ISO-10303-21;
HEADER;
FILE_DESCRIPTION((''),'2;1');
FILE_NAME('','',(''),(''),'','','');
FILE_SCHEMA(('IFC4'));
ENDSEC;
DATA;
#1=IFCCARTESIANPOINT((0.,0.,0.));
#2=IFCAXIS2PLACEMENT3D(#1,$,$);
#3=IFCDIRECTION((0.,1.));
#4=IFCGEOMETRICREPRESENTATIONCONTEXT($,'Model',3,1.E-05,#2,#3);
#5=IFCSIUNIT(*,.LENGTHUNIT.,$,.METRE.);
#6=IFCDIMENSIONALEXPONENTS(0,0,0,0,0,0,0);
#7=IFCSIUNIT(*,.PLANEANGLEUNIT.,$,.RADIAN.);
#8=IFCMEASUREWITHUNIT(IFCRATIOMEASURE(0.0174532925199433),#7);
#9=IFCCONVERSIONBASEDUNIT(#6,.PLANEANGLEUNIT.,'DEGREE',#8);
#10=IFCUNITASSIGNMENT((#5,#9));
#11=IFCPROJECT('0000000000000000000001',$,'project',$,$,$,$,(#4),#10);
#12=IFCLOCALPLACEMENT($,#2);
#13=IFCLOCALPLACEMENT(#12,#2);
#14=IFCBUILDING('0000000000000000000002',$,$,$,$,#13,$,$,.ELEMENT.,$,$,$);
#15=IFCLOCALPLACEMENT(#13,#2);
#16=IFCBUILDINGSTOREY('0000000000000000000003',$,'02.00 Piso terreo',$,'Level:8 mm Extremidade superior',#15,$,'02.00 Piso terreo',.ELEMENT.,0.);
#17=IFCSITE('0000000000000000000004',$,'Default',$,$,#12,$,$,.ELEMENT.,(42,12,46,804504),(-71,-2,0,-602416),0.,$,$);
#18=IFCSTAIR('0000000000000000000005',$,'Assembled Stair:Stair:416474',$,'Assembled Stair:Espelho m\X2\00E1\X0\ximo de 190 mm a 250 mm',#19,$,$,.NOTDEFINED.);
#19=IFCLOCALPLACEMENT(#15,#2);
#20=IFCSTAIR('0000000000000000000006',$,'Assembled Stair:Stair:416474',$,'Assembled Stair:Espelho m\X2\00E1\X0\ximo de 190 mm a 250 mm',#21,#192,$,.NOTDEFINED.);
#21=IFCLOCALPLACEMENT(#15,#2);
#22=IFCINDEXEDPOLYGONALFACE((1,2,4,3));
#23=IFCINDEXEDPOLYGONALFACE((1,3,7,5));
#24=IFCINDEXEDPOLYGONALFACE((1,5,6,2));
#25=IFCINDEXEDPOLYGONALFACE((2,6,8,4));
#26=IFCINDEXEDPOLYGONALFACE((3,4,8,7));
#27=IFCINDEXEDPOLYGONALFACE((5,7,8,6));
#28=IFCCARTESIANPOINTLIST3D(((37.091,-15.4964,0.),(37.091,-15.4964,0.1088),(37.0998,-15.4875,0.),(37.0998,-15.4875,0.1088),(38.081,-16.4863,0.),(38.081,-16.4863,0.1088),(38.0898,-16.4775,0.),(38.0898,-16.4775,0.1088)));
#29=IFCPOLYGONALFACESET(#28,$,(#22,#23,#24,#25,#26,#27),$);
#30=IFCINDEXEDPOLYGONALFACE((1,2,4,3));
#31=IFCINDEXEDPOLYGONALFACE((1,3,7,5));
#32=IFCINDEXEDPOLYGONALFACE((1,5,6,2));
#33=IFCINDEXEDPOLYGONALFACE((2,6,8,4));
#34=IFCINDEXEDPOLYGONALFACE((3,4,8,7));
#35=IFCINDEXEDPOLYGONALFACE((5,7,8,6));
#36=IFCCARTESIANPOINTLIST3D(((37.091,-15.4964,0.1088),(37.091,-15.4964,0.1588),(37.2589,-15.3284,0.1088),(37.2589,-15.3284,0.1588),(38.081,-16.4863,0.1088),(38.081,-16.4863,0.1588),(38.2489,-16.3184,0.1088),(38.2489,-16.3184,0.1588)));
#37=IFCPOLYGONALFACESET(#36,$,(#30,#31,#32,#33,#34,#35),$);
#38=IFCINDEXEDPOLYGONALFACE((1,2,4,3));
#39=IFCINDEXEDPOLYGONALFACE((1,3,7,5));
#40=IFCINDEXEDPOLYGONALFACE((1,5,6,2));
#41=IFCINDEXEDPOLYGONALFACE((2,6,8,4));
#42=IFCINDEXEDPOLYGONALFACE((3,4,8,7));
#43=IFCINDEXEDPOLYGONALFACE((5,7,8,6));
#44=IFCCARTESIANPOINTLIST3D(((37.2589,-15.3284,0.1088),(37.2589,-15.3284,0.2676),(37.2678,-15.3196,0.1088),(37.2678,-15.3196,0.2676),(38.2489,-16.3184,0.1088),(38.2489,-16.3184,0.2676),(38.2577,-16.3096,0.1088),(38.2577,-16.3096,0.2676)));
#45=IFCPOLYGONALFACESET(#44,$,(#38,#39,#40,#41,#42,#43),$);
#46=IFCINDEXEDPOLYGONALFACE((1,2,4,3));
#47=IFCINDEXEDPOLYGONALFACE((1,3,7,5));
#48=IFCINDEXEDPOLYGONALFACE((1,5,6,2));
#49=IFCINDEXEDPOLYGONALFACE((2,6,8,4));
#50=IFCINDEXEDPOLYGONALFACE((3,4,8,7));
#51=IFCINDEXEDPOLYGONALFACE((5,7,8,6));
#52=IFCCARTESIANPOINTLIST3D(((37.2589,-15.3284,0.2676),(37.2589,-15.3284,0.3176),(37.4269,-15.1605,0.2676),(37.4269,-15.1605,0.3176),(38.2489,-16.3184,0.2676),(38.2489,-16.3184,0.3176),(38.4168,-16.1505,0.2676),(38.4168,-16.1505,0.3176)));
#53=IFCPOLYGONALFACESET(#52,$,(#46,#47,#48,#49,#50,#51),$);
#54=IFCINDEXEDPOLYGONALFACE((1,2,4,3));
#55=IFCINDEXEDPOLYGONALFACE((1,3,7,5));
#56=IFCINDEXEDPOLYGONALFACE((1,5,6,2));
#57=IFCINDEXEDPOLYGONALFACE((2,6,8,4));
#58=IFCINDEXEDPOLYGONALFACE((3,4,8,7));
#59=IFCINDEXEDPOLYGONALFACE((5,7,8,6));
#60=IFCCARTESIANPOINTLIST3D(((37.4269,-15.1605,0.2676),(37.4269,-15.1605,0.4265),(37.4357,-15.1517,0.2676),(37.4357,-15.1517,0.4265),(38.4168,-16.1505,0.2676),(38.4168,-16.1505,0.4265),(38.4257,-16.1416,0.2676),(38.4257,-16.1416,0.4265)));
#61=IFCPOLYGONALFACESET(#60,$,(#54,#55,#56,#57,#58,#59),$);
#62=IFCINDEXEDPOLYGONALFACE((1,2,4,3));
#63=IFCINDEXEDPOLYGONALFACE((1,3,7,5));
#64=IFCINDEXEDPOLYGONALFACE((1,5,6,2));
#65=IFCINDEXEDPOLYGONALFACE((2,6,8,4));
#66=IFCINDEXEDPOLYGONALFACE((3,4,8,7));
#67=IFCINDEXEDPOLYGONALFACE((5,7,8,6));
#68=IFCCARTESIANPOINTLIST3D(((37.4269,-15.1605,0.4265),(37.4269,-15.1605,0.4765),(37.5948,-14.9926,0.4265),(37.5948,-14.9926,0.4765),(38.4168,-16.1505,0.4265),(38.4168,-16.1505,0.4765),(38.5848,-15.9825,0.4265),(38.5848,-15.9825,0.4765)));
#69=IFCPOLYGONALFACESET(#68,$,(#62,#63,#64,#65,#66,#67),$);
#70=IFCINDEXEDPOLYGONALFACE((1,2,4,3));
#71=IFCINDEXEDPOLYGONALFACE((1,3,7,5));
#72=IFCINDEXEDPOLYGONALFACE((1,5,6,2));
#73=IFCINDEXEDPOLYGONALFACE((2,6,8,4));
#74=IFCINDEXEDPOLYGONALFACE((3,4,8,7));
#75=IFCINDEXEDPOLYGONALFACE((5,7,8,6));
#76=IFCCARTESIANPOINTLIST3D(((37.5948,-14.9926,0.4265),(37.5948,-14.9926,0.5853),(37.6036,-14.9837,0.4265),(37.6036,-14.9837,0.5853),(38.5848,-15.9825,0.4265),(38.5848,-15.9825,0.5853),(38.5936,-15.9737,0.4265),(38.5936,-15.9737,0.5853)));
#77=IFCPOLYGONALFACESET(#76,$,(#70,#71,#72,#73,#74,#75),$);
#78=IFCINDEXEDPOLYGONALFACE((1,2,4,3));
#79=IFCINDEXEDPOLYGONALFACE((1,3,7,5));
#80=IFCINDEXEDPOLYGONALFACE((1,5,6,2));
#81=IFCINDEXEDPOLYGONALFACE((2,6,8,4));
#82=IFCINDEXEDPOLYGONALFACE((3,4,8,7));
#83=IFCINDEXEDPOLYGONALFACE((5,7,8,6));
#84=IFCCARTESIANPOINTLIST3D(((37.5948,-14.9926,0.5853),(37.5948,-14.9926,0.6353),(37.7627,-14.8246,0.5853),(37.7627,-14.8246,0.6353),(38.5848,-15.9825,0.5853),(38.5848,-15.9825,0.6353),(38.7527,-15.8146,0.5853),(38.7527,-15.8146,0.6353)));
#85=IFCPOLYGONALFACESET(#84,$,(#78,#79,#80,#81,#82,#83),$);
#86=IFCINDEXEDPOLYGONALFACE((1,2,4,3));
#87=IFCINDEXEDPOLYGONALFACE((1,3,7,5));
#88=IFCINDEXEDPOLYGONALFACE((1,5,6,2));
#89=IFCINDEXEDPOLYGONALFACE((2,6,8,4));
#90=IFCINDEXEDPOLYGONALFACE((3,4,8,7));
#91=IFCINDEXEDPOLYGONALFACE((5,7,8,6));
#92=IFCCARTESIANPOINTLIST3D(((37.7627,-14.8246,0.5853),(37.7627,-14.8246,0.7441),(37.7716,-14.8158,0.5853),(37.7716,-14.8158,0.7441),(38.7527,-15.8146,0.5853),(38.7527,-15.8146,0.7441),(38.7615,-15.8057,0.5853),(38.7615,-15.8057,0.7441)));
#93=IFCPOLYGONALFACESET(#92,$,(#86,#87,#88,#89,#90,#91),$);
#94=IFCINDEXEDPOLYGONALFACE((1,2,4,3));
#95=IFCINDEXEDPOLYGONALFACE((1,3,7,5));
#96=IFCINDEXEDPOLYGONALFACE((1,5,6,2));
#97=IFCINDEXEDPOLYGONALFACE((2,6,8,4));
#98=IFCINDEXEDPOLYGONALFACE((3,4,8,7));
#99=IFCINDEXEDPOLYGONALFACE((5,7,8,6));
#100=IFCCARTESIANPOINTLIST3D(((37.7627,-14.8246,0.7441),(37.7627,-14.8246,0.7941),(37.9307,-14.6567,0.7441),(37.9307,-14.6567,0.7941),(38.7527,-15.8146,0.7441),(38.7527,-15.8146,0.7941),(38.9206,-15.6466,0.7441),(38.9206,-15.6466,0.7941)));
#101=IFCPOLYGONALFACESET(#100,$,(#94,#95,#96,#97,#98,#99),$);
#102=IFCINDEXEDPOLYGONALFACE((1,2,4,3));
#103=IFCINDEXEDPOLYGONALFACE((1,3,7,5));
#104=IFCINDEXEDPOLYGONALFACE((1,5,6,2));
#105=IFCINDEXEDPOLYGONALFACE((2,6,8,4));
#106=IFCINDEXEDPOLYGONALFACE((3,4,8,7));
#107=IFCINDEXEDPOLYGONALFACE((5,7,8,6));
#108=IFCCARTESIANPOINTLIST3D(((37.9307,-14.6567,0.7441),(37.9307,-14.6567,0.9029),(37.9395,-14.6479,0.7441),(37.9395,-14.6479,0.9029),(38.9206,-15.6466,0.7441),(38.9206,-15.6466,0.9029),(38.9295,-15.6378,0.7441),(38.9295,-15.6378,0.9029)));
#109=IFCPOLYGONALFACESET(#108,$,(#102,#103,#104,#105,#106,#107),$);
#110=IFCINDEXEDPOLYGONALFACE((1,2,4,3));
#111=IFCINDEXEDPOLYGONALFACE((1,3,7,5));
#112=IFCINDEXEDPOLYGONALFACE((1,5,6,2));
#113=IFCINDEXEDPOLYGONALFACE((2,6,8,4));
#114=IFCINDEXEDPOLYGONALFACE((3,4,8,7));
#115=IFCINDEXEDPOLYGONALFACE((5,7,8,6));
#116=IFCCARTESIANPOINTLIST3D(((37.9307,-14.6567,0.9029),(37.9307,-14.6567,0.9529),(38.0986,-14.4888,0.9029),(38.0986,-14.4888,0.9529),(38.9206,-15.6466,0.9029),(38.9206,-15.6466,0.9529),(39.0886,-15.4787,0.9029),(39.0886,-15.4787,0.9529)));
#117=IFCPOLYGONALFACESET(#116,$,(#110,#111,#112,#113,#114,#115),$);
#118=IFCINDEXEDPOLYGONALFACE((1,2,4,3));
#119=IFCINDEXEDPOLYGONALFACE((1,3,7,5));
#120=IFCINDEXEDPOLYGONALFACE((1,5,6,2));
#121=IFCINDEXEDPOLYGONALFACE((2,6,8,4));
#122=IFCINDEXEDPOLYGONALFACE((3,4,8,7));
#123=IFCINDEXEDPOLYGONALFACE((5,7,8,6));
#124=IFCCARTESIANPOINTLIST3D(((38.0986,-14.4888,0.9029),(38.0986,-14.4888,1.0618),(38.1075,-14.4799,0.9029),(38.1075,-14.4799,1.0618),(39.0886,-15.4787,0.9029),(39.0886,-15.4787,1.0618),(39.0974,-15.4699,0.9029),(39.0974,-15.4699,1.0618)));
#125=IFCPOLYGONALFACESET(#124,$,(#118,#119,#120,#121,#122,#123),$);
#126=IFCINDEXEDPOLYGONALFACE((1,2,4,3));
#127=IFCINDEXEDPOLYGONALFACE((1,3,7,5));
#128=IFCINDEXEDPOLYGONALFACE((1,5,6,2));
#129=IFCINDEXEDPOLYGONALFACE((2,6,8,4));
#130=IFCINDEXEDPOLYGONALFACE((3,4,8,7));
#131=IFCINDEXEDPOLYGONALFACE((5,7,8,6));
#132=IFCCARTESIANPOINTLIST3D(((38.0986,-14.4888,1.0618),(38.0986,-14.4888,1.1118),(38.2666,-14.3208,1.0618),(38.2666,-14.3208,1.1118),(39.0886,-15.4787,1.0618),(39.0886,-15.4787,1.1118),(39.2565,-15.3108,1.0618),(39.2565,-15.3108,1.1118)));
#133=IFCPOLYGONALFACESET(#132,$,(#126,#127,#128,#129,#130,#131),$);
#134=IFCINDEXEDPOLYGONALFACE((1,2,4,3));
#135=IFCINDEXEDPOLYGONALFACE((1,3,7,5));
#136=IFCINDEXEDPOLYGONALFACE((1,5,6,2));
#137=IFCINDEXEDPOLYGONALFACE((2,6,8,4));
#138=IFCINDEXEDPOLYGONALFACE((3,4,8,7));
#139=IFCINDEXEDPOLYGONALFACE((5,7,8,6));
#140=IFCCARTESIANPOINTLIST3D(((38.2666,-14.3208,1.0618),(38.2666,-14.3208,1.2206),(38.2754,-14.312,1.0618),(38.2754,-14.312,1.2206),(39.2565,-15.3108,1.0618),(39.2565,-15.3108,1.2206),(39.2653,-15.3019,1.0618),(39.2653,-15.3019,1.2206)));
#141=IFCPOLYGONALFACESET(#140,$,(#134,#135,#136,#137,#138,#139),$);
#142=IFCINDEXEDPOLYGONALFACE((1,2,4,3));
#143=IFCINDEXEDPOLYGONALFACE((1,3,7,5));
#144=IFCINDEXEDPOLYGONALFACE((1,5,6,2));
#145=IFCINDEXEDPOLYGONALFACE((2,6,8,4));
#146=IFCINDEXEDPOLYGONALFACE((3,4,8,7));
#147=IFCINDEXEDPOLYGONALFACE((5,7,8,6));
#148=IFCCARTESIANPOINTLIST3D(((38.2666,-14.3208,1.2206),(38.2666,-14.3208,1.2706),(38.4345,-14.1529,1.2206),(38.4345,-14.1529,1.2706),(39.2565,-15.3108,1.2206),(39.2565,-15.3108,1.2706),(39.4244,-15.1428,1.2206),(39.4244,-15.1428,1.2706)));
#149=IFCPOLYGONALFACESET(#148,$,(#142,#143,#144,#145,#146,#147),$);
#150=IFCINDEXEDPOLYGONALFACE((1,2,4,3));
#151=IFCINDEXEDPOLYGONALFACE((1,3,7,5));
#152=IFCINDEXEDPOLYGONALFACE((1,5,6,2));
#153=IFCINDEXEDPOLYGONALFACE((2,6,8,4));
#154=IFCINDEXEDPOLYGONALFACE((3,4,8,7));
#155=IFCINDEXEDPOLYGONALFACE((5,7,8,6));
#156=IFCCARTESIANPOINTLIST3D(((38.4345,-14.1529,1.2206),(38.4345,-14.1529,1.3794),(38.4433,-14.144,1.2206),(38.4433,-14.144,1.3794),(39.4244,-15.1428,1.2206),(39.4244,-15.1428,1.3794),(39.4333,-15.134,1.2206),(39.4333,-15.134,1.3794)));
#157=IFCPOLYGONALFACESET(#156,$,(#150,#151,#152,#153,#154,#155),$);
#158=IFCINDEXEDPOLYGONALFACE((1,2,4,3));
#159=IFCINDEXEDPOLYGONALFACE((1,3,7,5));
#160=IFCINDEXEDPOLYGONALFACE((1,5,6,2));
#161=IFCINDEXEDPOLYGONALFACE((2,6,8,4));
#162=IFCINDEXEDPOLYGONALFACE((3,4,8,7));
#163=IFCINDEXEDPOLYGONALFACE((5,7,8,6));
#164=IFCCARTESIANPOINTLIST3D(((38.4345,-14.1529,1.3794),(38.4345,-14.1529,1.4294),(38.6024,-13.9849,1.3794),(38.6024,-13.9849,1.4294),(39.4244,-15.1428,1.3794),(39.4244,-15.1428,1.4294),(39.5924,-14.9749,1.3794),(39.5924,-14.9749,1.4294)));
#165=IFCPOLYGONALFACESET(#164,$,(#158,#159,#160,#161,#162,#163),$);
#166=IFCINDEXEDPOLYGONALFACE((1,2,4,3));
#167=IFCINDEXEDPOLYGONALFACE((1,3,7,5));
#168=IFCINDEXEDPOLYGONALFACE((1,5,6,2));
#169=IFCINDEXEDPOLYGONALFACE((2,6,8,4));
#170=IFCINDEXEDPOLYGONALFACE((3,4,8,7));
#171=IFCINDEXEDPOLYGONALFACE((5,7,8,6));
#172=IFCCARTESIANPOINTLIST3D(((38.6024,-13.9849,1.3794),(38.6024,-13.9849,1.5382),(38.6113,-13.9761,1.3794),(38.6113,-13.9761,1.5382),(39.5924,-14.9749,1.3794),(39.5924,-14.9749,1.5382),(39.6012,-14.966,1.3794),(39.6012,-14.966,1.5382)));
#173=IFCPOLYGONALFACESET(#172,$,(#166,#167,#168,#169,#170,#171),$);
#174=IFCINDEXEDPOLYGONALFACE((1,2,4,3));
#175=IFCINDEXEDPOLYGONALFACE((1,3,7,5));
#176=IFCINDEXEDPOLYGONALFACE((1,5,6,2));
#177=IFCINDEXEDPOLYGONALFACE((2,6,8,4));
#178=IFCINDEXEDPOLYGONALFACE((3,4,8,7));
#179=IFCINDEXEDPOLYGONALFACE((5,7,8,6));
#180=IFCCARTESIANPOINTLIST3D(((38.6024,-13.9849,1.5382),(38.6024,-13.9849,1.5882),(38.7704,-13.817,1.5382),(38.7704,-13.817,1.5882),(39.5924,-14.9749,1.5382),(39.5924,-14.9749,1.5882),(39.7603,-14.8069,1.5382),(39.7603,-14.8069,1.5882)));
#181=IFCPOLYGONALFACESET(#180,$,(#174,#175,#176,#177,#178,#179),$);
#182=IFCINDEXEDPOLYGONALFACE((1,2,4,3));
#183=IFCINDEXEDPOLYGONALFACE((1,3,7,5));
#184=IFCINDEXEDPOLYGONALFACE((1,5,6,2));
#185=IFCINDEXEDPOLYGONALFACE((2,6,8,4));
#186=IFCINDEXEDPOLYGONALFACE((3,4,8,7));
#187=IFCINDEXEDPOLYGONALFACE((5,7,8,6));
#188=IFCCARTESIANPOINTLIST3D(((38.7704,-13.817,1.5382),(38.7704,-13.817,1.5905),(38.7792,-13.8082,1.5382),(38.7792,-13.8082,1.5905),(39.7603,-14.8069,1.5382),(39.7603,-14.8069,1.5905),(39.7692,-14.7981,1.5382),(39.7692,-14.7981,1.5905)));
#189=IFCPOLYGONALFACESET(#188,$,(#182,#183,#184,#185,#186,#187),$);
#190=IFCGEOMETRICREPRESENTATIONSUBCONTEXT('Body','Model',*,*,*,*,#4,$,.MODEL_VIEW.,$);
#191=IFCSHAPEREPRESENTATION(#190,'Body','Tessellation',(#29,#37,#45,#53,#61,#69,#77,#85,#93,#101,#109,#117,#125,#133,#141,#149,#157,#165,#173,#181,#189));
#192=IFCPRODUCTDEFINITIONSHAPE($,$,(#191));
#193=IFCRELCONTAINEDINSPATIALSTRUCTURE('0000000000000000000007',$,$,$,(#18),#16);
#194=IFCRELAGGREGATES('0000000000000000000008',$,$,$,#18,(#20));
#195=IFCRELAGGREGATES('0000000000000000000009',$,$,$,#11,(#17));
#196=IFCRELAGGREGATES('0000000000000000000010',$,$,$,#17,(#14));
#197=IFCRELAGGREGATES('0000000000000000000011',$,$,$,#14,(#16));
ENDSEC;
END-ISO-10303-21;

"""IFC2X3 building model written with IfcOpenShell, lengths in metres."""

from ifc_helpers import new_model, entity, si_unit, converted_unit, direction, frame, frame_2d, origin, origin_2d_with_axis, place, context, subcontext, project, spatial, rectangle, extrude, element, aggregate, save


model = new_model("IFC2X3")

# Units and contexts
model_context = context("Model", 3, precision=1e-05, world=origin(), true_north=direction((0.0, 1.0)))
body_context = subcontext(model_context, "Body", "Model", "MODEL_VIEW")
ifc_project = project(units=[si_unit("LENGTHUNIT", "METRE"), converted_unit("PLANEANGLEUNIT", "DEGREE", entity("IfcRatioMeasure", 0.0174532925199433), si_unit("PLANEANGLEUNIT", "RADIAN"), dimensions=[0, 0, 0, 0, 0, 0, 0])], contexts=[model_context])

# Site, building, storey
site_placement = place(None, origin())
site = spatial("IfcSite", under=ifc_project, at=site_placement, Name="Default", CompositionType="ELEMENT", RefLatitude=(42, 12, 46, 804504), RefLongitude=(-71, -2, 0, -602416), RefElevation=0.0)
building_placement = place(site_placement, origin())
building = spatial("IfcBuilding", under=site, at=building_placement, CompositionType="ELEMENT")
storey_placement = place(building_placement, origin())
storey = spatial("IfcBuildingStorey", under=building, at=storey_placement, Name="02.00 Piso terreo", ObjectType="Level:8 mm Extremidade superior", LongName="02.00 Piso terreo", CompositionType="ELEMENT", Elevation=0.0)

# Stairs
stair_1_placement = place(storey_placement, frame((37.091, -16.4863, 0.0)))
stair_1 = element("IfcStair", 1, at=stair_1_placement, inside=storey, Name="Assembled Stair:Stair:416474", ObjectType="Assembled Stair:Espelho máximo de 190 mm a 250 mm", ShapeType="NOTDEFINED")
stair_2_placement = place(stair_1_placement, origin())
stair_2 = element("IfcStair", 2, at=stair_2_placement, Name="Assembled Stair:Stair:416474", ObjectType="Assembled Stair:Espelho máximo de 190 mm a 250 mm", ShapeType="NOTDEFINED", context=body_context, shape_type="SweptSolid", body=[
    extrude(rectangle(XDim=1.4, YDim=0.0125, at=origin_2d_with_axis()), frame((0.4994, 0.4994, 0.0), z_axis=(0.0, 0.0, 1.0), x_axis=(-0.707111, 0.707103, 0.0)), (0.0, 0.0, 1.0), 0.1088),
    extrude(rectangle(XDim=0.2375, YDim=1.4, at=frame_2d((0.0, 0.0), x_axis=(1.0, 0.0))), frame((0.5789, 0.5789, 0.1088), z_axis=(0.0, 0.0, 1.0), x_axis=(-0.707103, -0.707111, 0.0)), (0.0, 0.0, 1.0), 0.05),
    extrude(rectangle(XDim=1.4, YDim=0.0125, at=frame_2d((0.0, 0.0), x_axis=(1.0, 0.0))), frame((0.6673, 0.6673, 0.1088), z_axis=(0.0, 0.0, 1.0), x_axis=(-0.707111, 0.707103, 0.0)), (0.0, 0.0, 1.0), 0.1588),
    extrude(rectangle(XDim=0.2375, YDim=1.4, at=origin_2d_with_axis()), frame((0.7469, 0.7469, 0.2676), z_axis=(0.0, 0.0, 1.0), x_axis=(-0.707103, -0.707111, 0.0)), (0.0, 0.0, 1.0), 0.05),
    extrude(rectangle(XDim=1.4, YDim=0.0125, at=origin_2d_with_axis()), frame((0.8353, 0.8353, 0.2676), z_axis=(0.0, 0.0, 1.0), x_axis=(-0.707111, 0.707103, 0.0)), (0.0, 0.0, 1.0), 0.1588),
    extrude(rectangle(XDim=0.2375, YDim=1.4, at=frame_2d((0.0, 0.0), x_axis=(1.0, 0.0))), frame((0.9148, 0.9148, 0.4265), z_axis=(0.0, 0.0, 1.0), x_axis=(-0.707103, -0.707111, 0.0)), (0.0, 0.0, 1.0), 0.05),
    extrude(rectangle(XDim=1.4, YDim=0.0125, at=origin_2d_with_axis()), frame((1.0032, 1.0032, 0.4265), z_axis=(0.0, 0.0, 1.0), x_axis=(-0.707111, 0.707103, 0.0)), (0.0, 0.0, 1.0), 0.1588),
    extrude(rectangle(XDim=0.2375, YDim=1.4, at=frame_2d((0.0, 0.0), x_axis=(1.0, 0.0))), frame((1.0828, 1.0828, 0.5853), z_axis=(0.0, 0.0, 1.0), x_axis=(-0.707103, -0.707111, 0.0)), (0.0, 0.0, 1.0), 0.05),
    extrude(rectangle(XDim=1.4, YDim=0.0125, at=origin_2d_with_axis()), frame((1.1711, 1.1711, 0.5853), z_axis=(0.0, 0.0, 1.0), x_axis=(-0.707111, 0.707103, 0.0)), (0.0, 0.0, 1.0), 0.1588),
    extrude(rectangle(XDim=0.2375, YDim=1.4, at=frame_2d((0.0, 0.0), x_axis=(1.0, 0.0))), frame((1.2507, 1.2507, 0.7441), z_axis=(0.0, 0.0, 1.0), x_axis=(-0.707103, -0.707111, 0.0)), (0.0, 0.0, 1.0), 0.05),
    extrude(rectangle(XDim=1.4, YDim=0.0125, at=frame_2d((0.0, 0.0), x_axis=(1.0, 0.0))), frame((1.3391, 1.3391, 0.7441), z_axis=(0.0, 0.0, 1.0), x_axis=(-0.707111, 0.707103, 0.0)), (0.0, 0.0, 1.0), 0.1588),
    extrude(rectangle(XDim=0.2375, YDim=1.4, at=origin_2d_with_axis()), frame((1.4186, 1.4186, 0.9029), z_axis=(0.0, 0.0, 1.0), x_axis=(-0.707103, -0.707111, 0.0)), (0.0, 0.0, 1.0), 0.05),
    extrude(rectangle(XDim=1.4, YDim=0.0125, at=origin_2d_with_axis()), frame((1.507, 1.507, 0.9029), z_axis=(0.0, 0.0, 1.0), x_axis=(-0.707111, 0.707103, 0.0)), (0.0, 0.0, 1.0), 0.1588),
    extrude(rectangle(XDim=0.2375, YDim=1.4, at=frame_2d((0.0, 0.0), x_axis=(1.0, 0.0))), frame((1.5866, 1.5866, 1.0618), z_axis=(0.0, 0.0, 1.0), x_axis=(-0.707103, -0.707111, 0.0)), (0.0, 0.0, 1.0), 0.05),
    extrude(rectangle(XDim=1.4, YDim=0.0125, at=frame_2d((0.0, 0.0), x_axis=(1.0, 0.0))), frame((1.675, 1.675, 1.0618), z_axis=(0.0, 0.0, 1.0), x_axis=(-0.707111, 0.707103, 0.0)), (0.0, 0.0, 1.0), 0.1588),
    extrude(rectangle(XDim=0.2375, YDim=1.4, at=frame_2d((0.0, 0.0), x_axis=(1.0, 0.0))), frame((1.7545, 1.7545, 1.2206), z_axis=(0.0, 0.0, 1.0), x_axis=(-0.707103, -0.707111, 0.0)), (0.0, 0.0, 1.0), 0.05),
    extrude(rectangle(XDim=1.4, YDim=0.0125, at=frame_2d((0.0, 0.0), x_axis=(1.0, 0.0))), frame((1.8429, 1.8429, 1.2206), z_axis=(0.0, 0.0, 1.0), x_axis=(-0.707111, 0.707103, 0.0)), (0.0, 0.0, 1.0), 0.1588),
    extrude(rectangle(XDim=0.2375, YDim=1.4, at=origin_2d_with_axis()), frame((1.9224, 1.9225, 1.3794), z_axis=(0.0, 0.0, 1.0), x_axis=(-0.707103, -0.707111, 0.0)), (0.0, 0.0, 1.0), 0.05),
    extrude(rectangle(XDim=1.4, YDim=0.0125, at=frame_2d((0.0, 0.0), x_axis=(1.0, 0.0))), frame((2.0108, 2.0108, 1.3794), z_axis=(0.0, 0.0, 1.0), x_axis=(-0.707111, 0.707103, 0.0)), (0.0, 0.0, 1.0), 0.1588),
    extrude(rectangle(XDim=0.2375, YDim=1.4, at=frame_2d((0.0, 0.0), x_axis=(1.0, 0.0))), frame((2.0904, 2.0904, 1.5382), z_axis=(0.0, 0.0, 1.0), x_axis=(-0.707103, -0.707111, 0.0)), (0.0, 0.0, 1.0), 0.05),
    extrude(rectangle(XDim=1.4, YDim=0.0125, at=frame_2d((0.0, 0.0), x_axis=(1.0, 0.0))), frame((2.1788, 2.1788, 1.5382), z_axis=(0.0, 0.0, 1.0), x_axis=(-0.707111, 0.707103, 0.0)), (0.0, 0.0, 1.0), 0.0522),
])
aggregate(stair_1, [stair_2])

save(model, "model.ifc")
